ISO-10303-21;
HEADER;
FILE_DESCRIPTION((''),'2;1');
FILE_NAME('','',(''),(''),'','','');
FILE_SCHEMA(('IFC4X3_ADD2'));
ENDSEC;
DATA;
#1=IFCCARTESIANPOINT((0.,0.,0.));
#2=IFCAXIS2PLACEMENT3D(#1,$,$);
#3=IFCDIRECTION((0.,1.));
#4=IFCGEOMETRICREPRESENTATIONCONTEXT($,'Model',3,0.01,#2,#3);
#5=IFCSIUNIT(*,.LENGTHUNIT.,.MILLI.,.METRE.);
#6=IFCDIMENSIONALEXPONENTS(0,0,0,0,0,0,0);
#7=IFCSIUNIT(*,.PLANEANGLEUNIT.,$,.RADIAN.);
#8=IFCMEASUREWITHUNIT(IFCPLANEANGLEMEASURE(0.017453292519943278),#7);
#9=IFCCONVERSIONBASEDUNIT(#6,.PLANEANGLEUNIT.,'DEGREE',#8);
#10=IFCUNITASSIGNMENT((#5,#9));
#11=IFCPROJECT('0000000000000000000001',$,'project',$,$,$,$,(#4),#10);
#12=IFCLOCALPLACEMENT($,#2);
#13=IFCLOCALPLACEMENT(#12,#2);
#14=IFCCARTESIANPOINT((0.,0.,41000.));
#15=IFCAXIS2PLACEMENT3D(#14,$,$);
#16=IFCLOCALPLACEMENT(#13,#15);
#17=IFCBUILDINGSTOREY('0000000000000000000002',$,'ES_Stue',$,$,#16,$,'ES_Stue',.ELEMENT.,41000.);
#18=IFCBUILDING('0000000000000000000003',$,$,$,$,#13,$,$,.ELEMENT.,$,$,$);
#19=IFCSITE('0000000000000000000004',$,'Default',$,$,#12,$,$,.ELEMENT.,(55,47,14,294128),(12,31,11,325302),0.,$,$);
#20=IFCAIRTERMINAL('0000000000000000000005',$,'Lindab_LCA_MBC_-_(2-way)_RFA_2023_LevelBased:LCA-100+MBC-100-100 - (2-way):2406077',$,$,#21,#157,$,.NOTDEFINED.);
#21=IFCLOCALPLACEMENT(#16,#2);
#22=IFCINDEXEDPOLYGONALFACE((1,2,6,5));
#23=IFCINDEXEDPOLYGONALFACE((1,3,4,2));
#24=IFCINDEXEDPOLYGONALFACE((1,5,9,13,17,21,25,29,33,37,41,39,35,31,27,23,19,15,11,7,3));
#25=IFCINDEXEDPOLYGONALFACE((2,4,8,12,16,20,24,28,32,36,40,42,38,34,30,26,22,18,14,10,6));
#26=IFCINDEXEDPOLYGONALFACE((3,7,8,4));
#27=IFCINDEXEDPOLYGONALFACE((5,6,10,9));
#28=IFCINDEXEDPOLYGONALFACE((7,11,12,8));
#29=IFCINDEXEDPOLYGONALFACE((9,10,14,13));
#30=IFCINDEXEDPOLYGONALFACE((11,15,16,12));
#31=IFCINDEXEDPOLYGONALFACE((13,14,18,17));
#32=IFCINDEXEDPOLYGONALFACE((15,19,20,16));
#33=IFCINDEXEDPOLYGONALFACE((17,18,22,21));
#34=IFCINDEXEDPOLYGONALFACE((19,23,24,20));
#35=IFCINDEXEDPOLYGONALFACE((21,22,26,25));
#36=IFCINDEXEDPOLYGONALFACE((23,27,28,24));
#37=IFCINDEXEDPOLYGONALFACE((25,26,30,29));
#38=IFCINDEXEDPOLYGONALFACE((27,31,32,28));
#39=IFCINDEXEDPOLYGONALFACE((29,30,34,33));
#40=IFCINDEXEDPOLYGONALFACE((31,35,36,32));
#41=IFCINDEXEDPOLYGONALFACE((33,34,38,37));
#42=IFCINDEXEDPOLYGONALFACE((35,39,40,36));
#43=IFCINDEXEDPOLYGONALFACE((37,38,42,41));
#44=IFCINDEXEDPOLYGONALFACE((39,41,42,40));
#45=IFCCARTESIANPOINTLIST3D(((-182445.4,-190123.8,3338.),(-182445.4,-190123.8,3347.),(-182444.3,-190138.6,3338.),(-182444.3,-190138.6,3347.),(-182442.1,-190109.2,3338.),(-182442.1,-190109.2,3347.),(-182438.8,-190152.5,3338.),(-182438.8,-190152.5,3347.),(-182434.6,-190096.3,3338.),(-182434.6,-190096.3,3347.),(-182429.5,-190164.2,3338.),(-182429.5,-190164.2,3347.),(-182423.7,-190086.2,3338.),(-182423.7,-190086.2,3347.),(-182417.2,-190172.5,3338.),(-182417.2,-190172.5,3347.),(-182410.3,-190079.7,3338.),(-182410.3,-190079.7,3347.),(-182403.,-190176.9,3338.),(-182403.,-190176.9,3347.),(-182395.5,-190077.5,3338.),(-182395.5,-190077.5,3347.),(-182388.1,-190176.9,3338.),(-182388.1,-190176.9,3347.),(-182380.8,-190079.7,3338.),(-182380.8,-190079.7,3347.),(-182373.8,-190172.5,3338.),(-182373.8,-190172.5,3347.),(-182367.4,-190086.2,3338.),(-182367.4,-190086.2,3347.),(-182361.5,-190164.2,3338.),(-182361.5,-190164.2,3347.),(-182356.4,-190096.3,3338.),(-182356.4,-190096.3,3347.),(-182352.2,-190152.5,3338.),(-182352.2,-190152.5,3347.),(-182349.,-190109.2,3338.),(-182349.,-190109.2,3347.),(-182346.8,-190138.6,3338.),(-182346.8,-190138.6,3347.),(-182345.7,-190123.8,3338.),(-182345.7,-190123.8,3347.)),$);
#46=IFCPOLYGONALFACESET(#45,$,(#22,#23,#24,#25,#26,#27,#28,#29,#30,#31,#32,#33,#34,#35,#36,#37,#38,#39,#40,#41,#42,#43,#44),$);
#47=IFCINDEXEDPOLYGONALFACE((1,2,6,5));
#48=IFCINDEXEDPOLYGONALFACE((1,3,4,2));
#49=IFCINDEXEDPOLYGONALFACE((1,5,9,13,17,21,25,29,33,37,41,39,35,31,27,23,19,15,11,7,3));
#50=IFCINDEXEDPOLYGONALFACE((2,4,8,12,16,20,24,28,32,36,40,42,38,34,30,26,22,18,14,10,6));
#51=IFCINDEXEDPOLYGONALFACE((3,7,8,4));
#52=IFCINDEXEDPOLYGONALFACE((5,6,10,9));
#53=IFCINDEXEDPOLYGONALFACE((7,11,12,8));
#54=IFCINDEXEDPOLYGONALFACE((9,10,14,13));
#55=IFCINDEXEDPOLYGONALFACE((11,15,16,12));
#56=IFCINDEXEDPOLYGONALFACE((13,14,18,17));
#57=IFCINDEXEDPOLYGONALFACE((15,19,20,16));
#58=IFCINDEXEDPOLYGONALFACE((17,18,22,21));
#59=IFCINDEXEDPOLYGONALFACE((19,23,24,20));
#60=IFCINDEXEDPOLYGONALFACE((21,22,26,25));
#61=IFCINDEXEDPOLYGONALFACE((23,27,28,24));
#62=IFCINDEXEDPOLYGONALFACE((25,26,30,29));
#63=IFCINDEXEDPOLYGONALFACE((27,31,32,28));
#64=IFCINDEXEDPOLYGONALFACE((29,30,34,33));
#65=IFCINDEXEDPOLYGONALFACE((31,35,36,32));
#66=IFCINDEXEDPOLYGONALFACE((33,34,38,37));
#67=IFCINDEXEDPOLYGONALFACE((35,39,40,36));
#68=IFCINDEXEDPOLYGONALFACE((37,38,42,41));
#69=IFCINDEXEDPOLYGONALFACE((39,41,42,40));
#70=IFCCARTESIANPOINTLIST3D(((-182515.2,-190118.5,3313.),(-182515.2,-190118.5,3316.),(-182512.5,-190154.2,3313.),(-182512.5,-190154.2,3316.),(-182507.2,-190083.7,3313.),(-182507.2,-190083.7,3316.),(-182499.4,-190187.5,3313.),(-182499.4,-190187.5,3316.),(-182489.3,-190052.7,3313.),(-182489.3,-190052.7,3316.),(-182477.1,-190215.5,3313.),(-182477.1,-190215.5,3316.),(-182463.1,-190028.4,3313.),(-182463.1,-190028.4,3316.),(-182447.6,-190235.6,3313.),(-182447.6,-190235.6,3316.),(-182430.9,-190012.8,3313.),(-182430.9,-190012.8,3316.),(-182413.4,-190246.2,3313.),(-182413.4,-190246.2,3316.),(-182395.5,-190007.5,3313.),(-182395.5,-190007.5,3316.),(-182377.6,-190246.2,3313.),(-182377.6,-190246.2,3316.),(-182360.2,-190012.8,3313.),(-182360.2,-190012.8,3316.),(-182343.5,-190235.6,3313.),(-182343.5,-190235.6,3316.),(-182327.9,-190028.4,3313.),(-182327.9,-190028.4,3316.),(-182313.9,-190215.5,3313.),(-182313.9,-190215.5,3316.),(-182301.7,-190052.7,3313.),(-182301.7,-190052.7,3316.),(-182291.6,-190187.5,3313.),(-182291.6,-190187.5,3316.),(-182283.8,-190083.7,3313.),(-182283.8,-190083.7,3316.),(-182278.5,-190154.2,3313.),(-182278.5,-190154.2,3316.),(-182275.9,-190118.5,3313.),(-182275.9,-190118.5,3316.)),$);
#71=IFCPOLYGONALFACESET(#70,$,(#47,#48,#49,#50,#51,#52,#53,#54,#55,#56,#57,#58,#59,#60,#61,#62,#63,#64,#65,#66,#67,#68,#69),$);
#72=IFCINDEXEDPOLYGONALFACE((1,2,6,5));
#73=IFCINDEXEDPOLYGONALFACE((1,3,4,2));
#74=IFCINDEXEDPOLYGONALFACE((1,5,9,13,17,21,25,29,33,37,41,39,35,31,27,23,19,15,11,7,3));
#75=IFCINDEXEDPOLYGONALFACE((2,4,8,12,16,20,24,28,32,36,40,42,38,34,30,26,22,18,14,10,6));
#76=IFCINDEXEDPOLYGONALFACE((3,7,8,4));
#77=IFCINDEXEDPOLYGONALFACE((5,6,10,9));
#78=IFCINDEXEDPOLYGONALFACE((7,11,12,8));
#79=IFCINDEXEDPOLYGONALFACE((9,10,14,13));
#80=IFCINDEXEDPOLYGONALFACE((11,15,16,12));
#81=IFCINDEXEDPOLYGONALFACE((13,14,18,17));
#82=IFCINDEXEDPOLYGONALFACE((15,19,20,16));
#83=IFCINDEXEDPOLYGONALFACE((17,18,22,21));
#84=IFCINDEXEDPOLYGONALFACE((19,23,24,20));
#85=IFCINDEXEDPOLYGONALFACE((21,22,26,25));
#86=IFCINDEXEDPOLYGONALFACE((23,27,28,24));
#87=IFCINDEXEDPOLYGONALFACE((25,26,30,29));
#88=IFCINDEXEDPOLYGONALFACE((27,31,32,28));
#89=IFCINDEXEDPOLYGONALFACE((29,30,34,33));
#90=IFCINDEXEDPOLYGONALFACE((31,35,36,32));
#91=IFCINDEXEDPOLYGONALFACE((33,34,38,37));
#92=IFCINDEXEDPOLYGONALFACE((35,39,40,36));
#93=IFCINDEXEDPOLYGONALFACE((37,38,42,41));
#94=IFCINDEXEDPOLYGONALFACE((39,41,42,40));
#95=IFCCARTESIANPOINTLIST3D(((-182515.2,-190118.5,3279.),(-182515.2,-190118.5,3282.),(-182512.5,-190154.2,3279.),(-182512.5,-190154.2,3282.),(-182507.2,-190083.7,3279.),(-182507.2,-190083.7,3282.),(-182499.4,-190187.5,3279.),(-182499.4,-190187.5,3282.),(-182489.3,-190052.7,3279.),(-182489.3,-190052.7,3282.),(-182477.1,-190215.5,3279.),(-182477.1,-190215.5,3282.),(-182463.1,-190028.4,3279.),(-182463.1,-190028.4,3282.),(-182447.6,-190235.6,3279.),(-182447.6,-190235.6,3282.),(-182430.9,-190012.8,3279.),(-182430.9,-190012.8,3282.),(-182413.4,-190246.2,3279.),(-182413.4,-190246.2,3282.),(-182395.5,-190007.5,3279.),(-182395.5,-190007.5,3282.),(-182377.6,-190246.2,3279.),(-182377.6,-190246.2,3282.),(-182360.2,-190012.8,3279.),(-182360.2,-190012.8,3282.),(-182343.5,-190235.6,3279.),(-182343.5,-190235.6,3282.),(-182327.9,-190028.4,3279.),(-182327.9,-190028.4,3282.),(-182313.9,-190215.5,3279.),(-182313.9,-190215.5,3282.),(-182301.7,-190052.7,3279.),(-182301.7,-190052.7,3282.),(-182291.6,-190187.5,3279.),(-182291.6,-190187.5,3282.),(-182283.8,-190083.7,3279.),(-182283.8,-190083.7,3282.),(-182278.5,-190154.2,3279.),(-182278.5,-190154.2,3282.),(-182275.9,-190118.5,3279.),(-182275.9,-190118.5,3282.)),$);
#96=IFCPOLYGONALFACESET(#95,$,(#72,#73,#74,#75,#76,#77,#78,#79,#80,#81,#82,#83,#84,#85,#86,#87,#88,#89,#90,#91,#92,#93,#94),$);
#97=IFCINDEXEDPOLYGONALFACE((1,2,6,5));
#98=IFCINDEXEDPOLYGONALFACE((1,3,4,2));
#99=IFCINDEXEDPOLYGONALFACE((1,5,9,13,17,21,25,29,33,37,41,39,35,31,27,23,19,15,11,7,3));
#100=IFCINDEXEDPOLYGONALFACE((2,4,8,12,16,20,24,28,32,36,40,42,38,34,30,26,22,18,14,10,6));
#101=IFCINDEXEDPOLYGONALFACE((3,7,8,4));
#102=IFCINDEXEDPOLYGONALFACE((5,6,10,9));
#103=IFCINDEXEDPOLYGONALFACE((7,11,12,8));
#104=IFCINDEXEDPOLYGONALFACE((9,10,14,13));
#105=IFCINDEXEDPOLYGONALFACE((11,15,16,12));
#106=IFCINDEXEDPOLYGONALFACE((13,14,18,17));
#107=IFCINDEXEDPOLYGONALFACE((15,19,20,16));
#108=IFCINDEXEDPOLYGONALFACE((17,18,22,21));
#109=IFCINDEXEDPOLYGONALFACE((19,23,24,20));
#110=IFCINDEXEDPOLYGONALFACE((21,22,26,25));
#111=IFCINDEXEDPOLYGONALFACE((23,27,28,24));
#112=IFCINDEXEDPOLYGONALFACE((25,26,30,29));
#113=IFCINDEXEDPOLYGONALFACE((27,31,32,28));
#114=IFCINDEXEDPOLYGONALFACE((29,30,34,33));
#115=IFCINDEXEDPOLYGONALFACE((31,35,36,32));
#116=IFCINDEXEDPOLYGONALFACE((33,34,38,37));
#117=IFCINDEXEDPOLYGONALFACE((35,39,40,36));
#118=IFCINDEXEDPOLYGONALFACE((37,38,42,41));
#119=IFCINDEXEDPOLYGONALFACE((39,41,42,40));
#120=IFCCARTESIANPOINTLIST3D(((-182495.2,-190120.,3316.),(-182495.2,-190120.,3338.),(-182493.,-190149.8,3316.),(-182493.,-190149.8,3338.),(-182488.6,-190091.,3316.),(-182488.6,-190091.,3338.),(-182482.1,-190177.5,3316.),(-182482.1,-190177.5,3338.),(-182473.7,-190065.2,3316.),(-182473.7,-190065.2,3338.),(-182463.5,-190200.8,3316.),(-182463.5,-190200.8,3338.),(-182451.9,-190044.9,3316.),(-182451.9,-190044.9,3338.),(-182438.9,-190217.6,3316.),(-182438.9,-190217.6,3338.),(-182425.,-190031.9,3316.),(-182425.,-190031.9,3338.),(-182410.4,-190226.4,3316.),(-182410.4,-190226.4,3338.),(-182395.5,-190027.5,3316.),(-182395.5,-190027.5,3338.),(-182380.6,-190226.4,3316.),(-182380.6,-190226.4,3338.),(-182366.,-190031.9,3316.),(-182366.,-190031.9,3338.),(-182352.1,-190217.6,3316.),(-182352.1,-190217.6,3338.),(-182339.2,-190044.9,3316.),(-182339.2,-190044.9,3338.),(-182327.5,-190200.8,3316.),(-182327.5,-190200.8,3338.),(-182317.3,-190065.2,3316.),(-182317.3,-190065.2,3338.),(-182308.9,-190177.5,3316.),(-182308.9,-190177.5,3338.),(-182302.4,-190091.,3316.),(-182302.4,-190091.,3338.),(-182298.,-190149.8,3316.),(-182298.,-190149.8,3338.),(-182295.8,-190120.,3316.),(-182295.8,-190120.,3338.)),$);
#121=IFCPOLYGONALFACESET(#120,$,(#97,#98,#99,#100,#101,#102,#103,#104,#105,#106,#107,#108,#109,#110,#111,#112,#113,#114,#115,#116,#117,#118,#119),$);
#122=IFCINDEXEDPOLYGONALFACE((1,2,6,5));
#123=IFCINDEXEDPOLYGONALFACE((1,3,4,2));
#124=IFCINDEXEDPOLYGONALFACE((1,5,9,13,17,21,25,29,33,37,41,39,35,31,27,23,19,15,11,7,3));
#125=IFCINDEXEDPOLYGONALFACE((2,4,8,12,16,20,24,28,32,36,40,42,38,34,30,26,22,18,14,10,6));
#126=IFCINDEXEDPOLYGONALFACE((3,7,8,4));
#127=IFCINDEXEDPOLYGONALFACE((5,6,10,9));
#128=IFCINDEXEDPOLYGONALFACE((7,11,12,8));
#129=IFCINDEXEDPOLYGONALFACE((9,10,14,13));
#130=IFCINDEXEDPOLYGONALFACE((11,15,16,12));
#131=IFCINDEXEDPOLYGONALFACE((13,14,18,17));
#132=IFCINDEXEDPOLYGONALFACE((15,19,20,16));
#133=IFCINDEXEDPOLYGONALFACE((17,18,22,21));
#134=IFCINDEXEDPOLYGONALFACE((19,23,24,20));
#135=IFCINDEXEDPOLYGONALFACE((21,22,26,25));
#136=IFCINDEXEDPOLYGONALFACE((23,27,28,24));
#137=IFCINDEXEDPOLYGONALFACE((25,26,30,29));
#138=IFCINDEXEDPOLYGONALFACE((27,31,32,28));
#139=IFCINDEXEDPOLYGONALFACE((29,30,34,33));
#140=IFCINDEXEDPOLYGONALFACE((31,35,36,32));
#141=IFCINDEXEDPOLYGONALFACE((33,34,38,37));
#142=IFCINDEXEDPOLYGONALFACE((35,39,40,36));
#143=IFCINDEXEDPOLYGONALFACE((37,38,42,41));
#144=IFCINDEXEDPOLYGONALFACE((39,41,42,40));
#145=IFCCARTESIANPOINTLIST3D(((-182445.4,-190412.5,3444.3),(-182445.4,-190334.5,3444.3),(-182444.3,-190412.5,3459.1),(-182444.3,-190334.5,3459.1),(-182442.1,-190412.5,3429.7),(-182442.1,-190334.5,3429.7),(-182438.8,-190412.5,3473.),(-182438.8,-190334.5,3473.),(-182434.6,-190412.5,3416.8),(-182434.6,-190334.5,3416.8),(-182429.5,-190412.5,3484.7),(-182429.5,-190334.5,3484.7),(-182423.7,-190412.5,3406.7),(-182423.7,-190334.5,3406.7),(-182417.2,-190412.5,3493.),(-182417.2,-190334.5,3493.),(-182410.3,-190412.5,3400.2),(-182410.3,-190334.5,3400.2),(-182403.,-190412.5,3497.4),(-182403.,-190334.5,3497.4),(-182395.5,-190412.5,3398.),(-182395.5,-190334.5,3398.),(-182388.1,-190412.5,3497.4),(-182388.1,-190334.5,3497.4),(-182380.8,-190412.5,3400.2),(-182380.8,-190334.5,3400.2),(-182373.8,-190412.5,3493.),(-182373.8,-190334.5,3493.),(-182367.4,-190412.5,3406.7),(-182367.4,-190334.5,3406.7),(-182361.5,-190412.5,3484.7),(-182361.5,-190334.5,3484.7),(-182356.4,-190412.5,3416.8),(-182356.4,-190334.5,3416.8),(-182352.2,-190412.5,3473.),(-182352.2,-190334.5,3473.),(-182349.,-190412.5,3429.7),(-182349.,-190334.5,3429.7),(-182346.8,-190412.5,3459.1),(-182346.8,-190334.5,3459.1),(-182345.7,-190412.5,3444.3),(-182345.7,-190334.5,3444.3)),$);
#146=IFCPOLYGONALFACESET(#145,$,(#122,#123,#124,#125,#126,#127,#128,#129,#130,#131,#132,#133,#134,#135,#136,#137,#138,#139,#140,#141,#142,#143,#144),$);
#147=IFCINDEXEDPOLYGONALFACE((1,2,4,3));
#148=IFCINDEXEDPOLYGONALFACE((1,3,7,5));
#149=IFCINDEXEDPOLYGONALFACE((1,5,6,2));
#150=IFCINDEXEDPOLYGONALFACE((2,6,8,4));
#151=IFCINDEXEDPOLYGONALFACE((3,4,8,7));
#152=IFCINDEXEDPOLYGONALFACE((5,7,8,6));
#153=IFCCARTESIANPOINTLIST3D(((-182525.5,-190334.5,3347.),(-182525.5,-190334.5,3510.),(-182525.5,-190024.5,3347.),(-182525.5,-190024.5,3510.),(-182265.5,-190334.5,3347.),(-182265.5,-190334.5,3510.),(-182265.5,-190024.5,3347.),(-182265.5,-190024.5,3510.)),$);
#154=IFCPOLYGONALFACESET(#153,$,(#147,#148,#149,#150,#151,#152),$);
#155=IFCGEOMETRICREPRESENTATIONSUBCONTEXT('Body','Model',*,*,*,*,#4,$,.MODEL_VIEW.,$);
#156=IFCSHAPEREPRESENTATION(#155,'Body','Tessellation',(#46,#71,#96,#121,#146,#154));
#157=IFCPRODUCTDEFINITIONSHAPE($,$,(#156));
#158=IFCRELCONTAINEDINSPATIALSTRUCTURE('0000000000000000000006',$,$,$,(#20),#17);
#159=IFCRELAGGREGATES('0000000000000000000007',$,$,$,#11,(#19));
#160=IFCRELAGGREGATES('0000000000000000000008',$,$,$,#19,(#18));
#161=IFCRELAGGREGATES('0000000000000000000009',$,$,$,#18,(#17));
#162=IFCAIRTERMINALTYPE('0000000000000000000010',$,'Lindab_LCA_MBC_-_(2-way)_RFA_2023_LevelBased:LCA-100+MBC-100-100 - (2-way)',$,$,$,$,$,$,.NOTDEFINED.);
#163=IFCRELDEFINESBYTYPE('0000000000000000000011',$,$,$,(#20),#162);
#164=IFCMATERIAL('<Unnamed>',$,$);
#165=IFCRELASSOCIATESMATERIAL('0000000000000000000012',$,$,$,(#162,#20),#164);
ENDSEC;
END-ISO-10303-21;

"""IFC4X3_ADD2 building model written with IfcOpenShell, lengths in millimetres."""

from ifc_helpers import new_model, entity, si_unit, converted_unit, direction, frame, frame_2d, origin, origin_2d_with_axis, place, context, subcontext, project, spatial, rectangle, circle, extrude, source, transform, mapped, material, type_object, type_shapes, element, save


model = new_model("IFC4X3_ADD2")

# Units and contexts
model_context = context("Model", 3, precision=0.01, world=origin(), true_north=direction((0.0, 1.0)))
body_context = subcontext(model_context, "Body", "Model", "MODEL_VIEW")
ifc_project = project(units=[si_unit("LENGTHUNIT", "METRE", prefix="MILLI"), converted_unit("PLANEANGLEUNIT", "DEGREE", entity("IfcPlaneAngleMeasure", 0.017453292519943278), si_unit("PLANEANGLEUNIT", "RADIAN"), dimensions=[0, 0, 0, 0, 0, 0, 0])], contexts=[model_context])

# Site, building, storey
site_placement = place(None, origin())
site = spatial("IfcSite", under=ifc_project, at=site_placement, Name="Default", CompositionType="ELEMENT", RefLatitude=(55, 47, 14, 294128), RefLongitude=(12, 31, 11, 325302), RefElevation=0.0)
building_placement = place(site_placement, origin())
building = spatial("IfcBuilding", under=site, at=building_placement, CompositionType="ELEMENT")
storey_placement = place(building_placement, frame((0.0, 0.0, 41000.0)))
storey = spatial("IfcBuildingStorey", under=building, at=storey_placement, Name="ES_Stue", LongName="ES_Stue", CompositionType="ELEMENT", Elevation=41000.0)

# Air terminal
ifc_material_1 = material(Name="<Unnamed>")
air_terminal_type = type_object("IfcAirTerminalType", Name="Lindab_LCA_MBC_-_(2-way)_RFA_2023_LevelBased:LCA-100+MBC-100-100 - (2-way)", PredefinedType="NOTDEFINED", material=ifc_material_1)
shared_shape_1 = source(origin(), body_context, "Body", "SweptSolid", [
    extrude(circle(Radius=50.0, at=frame_2d((0.0, 0.0), x_axis=(1.0, 0.0))), frame((0.0, 0.0, 22.0)), (0.0, 0.0, 1.0), 9.0),
    extrude(circle(Radius=120.0, at=frame_2d((0.0, 0.0), x_axis=(1.0, 0.0))), frame((0.0, 0.0, -3.0)), (0.0, 0.0, 1.0), 3.0),
    extrude(circle(Radius=120.0, at=frame_2d((0.0, 0.0), x_axis=(1.0, 0.0))), frame((0.0, 0.0, -37.0)), (0.0, 0.0, 1.0), 3.0),
    extrude(circle(Radius=100.0, at=frame_2d((0.0, 0.0), x_axis=(1.0, 0.0))), origin(), (0.0, 0.0, 1.0), 22.0),
    extrude(circle(Radius=50.0, at=frame_2d((0.0, 0.0), x_axis=(1.0, 0.0))), frame((-285.0, 0.0, 132.0), z_axis=(1.0, 0.0, 0.0), x_axis=(0.0, 0.0, -1.0)), (0.0, 0.0, 1.0), 78.0),
    extrude(rectangle(XDim=260.0, YDim=310.0, at=origin_2d_with_axis()), frame((-52.0, 0.0, 31.0), z_axis=(0.0, 0.0, 1.0), x_axis=(0.0, -1.0, 0.0)), (0.0, 0.0, 1.0), 163.0),
])
type_shapes(air_terminal_type, [shared_shape_1])
for number, where, z_axis, x_axis, name in (
    (1, (-182395.5, -190127.5, 3316.0), (0.0, 0.0, 1.0), (0.0, 1.0, 0.0), "Lindab_LCA_MBC_-_(2-way)_RFA_2023_LevelBased:LCA-100+MBC-100-100 - (2-way):2406077"),
):
    element("IfcAirTerminal", number, at=place(storey_placement, frame(where, z_axis=z_axis, x_axis=x_axis)), inside=storey, type_object=air_terminal_type, material=ifc_material_1, Name=name, PredefinedType="NOTDEFINED", context=body_context, shape_type="MappedRepresentation", body=[
        mapped(shared_shape_1, transform((0.0, 0.0, 0.0), scale=1.0)),
    ])

save(model, "model.ifc")
